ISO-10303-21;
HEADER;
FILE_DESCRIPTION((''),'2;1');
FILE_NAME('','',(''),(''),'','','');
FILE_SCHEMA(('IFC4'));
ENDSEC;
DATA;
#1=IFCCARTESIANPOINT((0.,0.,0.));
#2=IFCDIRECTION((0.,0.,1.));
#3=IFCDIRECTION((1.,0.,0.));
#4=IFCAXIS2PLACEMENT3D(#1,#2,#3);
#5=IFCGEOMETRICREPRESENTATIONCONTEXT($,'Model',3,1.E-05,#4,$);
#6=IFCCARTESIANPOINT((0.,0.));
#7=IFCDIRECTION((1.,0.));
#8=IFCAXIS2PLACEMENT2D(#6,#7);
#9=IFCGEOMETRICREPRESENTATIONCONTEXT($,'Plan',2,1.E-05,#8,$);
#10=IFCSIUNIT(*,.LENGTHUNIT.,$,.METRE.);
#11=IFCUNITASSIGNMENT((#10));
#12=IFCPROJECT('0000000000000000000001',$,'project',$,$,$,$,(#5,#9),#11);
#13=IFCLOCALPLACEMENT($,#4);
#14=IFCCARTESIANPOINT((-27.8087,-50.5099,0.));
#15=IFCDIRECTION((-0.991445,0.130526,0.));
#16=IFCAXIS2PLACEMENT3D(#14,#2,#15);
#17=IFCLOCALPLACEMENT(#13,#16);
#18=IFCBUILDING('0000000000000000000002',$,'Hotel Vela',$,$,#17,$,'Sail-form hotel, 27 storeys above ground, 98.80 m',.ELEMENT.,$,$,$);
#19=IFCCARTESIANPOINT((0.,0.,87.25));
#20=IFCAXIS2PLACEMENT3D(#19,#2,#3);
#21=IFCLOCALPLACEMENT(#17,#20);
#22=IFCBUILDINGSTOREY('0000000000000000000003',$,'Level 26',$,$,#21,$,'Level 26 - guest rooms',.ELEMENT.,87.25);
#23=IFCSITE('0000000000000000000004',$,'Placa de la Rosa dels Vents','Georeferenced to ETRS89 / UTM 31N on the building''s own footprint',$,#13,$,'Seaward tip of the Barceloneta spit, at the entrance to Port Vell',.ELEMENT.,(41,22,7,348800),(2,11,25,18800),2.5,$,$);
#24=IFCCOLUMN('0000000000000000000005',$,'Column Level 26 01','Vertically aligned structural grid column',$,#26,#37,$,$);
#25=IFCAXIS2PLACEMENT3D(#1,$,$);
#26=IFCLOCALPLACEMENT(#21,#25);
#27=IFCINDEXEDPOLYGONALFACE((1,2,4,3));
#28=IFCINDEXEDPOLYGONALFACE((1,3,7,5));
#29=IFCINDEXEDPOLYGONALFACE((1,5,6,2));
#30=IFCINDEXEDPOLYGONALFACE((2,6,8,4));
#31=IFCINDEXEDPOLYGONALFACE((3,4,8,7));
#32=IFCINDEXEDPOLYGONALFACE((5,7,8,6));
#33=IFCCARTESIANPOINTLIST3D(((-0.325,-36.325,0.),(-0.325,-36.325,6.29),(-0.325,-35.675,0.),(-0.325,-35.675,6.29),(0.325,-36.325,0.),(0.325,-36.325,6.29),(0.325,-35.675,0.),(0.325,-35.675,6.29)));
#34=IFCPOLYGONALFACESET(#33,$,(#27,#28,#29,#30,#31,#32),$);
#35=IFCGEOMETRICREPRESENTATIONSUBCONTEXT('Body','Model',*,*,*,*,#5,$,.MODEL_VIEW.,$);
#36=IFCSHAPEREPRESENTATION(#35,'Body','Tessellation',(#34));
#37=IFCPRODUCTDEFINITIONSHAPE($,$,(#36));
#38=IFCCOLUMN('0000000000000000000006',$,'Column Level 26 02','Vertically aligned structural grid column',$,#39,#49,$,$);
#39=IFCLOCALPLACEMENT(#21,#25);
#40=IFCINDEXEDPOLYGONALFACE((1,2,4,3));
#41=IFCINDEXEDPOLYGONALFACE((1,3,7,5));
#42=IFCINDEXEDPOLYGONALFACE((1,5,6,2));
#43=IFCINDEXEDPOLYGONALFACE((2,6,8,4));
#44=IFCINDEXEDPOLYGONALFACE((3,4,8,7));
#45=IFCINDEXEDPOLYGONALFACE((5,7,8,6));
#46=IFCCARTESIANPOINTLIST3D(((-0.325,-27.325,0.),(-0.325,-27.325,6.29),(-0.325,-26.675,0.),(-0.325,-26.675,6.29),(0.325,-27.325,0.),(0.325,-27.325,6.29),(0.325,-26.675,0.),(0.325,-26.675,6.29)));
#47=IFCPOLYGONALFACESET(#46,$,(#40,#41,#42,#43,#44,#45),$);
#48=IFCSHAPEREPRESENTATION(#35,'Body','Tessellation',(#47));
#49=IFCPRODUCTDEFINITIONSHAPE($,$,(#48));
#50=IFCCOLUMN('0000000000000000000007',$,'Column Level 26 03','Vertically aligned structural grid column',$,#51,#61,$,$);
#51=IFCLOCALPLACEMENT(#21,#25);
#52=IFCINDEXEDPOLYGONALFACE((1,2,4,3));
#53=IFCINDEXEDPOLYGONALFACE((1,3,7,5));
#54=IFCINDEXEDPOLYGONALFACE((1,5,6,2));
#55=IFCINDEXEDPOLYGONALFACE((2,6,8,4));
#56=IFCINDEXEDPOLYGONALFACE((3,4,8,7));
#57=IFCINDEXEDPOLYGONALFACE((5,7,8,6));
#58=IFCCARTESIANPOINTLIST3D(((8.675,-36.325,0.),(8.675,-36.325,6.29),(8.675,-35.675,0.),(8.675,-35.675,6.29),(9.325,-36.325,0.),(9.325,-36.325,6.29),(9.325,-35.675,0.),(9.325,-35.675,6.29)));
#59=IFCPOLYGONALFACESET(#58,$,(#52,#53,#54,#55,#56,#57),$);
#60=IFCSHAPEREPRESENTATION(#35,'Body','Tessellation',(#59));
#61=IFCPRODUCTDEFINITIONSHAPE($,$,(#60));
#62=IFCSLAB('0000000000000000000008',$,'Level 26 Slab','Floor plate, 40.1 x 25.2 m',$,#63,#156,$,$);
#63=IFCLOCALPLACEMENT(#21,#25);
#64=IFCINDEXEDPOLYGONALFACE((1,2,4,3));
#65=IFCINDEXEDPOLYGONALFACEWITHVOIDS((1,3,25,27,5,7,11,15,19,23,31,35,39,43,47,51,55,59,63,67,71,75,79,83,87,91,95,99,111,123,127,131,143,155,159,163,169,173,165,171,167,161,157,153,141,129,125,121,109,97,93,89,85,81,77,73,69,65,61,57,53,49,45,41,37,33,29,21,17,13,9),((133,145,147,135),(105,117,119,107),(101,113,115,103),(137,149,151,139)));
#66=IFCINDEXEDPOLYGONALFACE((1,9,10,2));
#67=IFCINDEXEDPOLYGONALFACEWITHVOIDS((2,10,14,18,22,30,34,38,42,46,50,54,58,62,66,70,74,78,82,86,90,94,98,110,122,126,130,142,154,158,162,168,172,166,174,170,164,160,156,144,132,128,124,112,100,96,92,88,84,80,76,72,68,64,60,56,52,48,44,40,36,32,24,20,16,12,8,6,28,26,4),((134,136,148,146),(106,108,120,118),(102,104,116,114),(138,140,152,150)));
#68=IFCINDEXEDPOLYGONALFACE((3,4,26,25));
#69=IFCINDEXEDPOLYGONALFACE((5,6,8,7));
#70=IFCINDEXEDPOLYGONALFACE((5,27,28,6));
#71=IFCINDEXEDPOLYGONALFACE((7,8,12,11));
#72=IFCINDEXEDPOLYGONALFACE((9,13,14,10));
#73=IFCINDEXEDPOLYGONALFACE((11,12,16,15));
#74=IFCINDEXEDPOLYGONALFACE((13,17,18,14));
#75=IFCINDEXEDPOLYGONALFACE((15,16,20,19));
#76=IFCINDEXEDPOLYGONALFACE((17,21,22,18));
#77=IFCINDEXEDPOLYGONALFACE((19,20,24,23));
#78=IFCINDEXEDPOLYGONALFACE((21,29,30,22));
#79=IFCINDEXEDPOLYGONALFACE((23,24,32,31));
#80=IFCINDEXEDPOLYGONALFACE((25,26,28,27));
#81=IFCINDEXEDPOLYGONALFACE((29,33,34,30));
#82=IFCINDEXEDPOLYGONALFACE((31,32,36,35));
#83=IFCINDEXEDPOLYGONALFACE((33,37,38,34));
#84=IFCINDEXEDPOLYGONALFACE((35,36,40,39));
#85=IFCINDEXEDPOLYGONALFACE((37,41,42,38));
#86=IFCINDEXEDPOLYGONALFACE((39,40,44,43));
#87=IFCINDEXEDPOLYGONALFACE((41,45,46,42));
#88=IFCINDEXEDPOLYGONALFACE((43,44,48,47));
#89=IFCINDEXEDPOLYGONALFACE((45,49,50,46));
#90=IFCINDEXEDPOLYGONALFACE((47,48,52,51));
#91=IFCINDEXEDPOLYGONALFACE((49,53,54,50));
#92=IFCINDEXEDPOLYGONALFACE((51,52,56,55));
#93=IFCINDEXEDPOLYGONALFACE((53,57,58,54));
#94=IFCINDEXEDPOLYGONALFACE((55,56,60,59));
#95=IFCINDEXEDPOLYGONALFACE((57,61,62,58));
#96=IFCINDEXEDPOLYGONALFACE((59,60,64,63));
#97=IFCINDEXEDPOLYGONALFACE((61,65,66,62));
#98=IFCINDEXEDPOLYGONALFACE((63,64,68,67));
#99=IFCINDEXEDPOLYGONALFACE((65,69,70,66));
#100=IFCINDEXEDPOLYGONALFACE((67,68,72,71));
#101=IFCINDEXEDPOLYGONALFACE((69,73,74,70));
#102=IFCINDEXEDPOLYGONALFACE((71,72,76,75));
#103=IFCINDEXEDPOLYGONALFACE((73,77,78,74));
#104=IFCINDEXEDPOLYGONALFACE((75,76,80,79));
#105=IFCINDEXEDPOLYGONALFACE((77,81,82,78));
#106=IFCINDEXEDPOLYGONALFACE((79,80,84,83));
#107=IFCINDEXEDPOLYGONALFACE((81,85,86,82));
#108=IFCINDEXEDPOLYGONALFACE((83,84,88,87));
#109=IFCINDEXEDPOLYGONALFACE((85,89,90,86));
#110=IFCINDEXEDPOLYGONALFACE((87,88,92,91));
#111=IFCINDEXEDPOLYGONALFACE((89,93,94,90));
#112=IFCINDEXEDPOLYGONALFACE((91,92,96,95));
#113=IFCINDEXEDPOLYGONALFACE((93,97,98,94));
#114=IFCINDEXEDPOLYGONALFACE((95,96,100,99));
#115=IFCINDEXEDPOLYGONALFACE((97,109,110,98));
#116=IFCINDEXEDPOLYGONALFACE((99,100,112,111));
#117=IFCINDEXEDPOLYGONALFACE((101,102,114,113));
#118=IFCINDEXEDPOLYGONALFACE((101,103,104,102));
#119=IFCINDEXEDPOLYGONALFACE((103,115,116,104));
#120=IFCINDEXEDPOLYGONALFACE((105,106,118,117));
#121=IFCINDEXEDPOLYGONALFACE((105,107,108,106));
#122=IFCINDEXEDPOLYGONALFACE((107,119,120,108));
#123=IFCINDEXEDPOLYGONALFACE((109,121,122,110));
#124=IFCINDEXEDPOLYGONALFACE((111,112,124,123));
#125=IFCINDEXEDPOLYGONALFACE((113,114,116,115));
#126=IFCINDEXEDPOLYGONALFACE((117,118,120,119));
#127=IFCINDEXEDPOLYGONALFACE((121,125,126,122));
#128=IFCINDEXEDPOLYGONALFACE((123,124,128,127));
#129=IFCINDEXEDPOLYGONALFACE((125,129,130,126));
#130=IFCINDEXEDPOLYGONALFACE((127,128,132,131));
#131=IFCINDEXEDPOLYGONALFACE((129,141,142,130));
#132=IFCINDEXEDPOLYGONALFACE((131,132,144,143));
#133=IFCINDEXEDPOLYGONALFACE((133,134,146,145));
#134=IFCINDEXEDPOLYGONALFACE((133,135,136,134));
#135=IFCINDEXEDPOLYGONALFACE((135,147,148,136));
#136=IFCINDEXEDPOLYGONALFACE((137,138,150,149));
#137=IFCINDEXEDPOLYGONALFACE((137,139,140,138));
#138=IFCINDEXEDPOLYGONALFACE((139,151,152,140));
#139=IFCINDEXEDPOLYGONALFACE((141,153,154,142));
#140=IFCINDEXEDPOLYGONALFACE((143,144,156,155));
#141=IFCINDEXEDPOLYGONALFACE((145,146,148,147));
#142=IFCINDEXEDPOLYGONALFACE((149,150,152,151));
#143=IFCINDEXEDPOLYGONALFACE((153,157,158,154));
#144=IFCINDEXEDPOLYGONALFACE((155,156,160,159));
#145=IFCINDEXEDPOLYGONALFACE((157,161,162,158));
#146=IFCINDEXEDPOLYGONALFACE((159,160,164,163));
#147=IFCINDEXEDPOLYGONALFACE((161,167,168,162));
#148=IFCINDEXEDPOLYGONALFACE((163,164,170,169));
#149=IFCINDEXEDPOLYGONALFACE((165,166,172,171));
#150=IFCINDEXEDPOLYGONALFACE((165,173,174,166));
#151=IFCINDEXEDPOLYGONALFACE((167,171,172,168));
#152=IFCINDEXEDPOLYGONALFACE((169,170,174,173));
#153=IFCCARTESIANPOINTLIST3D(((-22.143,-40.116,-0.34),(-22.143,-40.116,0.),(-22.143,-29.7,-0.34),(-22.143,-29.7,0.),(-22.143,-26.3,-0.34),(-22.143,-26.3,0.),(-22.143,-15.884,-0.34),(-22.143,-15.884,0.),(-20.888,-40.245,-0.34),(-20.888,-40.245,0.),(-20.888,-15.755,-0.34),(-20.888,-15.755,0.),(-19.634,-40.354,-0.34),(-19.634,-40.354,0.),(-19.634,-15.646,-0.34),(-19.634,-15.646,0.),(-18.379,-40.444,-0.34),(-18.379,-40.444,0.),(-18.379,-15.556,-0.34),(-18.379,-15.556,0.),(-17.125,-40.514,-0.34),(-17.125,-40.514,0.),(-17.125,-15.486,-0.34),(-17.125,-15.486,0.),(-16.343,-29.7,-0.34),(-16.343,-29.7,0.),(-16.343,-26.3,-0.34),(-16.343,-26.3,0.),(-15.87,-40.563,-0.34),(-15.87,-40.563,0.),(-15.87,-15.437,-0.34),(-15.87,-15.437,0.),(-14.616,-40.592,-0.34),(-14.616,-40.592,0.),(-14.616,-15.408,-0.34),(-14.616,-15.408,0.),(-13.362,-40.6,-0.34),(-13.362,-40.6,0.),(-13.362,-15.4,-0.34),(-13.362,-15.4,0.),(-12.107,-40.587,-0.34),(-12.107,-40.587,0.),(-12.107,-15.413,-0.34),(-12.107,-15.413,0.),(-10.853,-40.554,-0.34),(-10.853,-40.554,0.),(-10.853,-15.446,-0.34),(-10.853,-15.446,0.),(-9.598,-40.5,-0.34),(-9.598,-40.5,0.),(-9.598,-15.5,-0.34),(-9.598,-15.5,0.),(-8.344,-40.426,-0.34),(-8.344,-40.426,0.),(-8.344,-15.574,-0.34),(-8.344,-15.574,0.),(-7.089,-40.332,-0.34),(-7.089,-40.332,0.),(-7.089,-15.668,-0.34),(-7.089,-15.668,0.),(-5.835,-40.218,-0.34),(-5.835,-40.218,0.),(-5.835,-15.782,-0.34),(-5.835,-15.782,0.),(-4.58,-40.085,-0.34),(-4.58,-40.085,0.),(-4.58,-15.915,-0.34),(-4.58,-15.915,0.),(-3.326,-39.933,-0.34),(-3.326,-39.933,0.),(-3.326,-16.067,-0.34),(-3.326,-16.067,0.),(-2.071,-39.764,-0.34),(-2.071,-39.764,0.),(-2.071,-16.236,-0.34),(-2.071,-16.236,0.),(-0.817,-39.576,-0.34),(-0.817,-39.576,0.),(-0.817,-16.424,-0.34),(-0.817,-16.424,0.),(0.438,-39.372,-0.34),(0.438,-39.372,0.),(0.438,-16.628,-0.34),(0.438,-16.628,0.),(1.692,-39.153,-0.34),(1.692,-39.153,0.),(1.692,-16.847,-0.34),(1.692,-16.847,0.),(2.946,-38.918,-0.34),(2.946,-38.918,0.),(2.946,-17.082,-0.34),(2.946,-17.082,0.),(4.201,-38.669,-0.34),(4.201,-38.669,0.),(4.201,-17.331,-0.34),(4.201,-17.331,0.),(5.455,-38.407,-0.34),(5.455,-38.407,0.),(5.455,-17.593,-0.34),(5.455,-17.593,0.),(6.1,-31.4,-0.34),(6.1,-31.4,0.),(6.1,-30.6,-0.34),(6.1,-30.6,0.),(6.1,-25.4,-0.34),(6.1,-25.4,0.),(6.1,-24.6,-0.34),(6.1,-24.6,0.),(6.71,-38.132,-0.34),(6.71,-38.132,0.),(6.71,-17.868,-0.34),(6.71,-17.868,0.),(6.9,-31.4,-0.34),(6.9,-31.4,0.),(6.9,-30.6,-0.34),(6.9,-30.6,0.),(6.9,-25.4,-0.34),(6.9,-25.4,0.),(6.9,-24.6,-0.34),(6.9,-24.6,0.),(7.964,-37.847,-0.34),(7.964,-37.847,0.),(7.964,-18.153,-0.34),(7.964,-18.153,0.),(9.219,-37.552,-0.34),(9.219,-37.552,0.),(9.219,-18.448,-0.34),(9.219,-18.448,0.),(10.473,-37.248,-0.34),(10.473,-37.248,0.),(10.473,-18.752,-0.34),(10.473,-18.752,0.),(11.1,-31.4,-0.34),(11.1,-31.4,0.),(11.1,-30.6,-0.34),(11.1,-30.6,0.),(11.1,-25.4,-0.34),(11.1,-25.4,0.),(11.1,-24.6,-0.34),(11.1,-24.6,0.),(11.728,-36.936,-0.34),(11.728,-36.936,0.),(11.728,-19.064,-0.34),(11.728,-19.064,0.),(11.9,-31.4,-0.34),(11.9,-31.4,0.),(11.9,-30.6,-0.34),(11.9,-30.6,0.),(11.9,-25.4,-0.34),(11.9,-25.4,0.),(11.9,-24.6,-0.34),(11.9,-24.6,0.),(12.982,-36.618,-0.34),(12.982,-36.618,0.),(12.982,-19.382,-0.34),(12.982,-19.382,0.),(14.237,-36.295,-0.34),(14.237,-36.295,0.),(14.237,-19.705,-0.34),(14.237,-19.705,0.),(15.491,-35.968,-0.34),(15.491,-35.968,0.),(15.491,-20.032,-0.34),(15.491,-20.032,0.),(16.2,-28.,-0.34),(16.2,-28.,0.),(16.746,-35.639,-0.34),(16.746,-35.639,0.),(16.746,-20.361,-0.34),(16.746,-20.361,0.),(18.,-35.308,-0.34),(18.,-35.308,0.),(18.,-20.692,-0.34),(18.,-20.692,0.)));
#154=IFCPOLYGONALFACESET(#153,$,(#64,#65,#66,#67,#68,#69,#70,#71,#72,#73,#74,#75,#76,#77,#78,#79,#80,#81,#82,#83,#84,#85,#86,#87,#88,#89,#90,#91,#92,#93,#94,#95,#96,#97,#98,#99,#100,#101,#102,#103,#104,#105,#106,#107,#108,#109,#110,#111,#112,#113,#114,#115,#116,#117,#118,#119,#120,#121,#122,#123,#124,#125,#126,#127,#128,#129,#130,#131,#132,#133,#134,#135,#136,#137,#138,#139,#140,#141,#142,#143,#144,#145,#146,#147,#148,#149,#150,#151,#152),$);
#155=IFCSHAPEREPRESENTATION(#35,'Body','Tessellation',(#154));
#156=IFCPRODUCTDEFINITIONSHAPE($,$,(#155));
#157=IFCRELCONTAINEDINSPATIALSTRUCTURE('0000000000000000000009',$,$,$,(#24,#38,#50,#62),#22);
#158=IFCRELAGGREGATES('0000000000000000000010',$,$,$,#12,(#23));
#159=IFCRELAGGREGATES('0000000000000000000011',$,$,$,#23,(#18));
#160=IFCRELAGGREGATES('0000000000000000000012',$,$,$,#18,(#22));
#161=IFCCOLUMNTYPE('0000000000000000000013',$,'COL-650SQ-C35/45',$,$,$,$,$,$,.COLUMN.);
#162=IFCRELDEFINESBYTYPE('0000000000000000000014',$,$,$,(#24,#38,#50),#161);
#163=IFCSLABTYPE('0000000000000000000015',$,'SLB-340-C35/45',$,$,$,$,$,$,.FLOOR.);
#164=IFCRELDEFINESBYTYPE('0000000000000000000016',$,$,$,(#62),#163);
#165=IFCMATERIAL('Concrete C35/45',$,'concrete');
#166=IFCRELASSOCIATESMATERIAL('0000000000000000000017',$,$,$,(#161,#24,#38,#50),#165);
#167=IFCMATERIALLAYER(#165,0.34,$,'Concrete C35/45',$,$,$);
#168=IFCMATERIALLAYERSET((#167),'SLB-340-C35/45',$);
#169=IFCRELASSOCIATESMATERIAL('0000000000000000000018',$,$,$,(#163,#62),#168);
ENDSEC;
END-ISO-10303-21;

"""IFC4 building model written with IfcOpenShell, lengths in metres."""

from ifc_helpers import new_model, si_unit, frame, origin_with_axes, origin_2d_with_axis, place, context, subcontext, project, spatial, line, indexed_curve, rectangle, outline, extrude, material, layer, layer_set, layer_usage, material_profile, profile_set, profile_usage, type_object, element, save


model = new_model("IFC4")

# Units and contexts
model_context = context("Model", 3, precision=1e-05, world=origin_with_axes())
plan_context = context("Plan", 2, precision=1e-05, world=origin_2d_with_axis())
body_context = subcontext(model_context, "Body", "Model", "MODEL_VIEW")
ifc_project = project(units=[si_unit("LENGTHUNIT", "METRE")], contexts=[model_context, plan_context])

# Site, building, storey
site_placement = place(None, origin_with_axes())
site = spatial("IfcSite", under=ifc_project, at=site_placement, Name="Placa de la Rosa dels Vents", Description="Georeferenced to ETRS89 / UTM 31N on the building's own footprint", LongName="Seaward tip of the Barceloneta spit, at the entrance to Port Vell", CompositionType="ELEMENT", RefLatitude=(41, 22, 7, 348800), RefLongitude=(2, 11, 25, 18800), RefElevation=2.5)
building_placement = place(site_placement, frame((-27.8087, -50.5099, 0.0), z_axis=(0.0, 0.0, 1.0), x_axis=(-0.991445, 0.130526, 0.0)))
building = spatial("IfcBuilding", under=site, at=building_placement, Name="Hotel Vela", LongName="Sail-form hotel, 27 storeys above ground, 98.80 m", CompositionType="ELEMENT")
storey_placement = place(building_placement, frame((0.0, 0.0, 87.25), z_axis=(0.0, 0.0, 1.0), x_axis=(1.0, 0.0, 0.0)))
storey = spatial("IfcBuildingStorey", under=building, at=storey_placement, Name="Level 26", LongName="Level 26 - guest rooms", CompositionType="ELEMENT", Elevation=87.25)

# Columns
ifc_material = material(Name="Concrete C35/45", Category="concrete")
ifc_material_profile = material_profile(ifc_material, rectangle(XDim=0.65, YDim=0.65))
ifc_profile_set = profile_set([ifc_material_profile], Name="COL-650SQ-C35/45")
ifc_profile_usage_1 = profile_usage(ifc_profile_set)
column_type = type_object("IfcColumnType", Name="COL-650SQ-C35/45", PredefinedType="COLUMN", material=ifc_profile_set)
column_1_placement = place(storey_placement, frame((-0.325, -36.325, 0.0), z_axis=(0.0, 0.0, 1.0), x_axis=(1.0, 0.0, 0.0)))
element("IfcColumn", 1, at=column_1_placement, inside=storey, type_object=column_type, material=ifc_profile_usage_1, Name="Column Level 26 01", Description="Vertically aligned structural grid column", context=body_context, shape_type="SweptSolid", body=[
    extrude(outline(indexed_curve([(0.0, 0.0), (0.65, 0.0), (0.65, 0.65), (0.0, 0.65)], segments=[line(1, 2, 3, 4, 1)])), origin_with_axes(), (0.0, 0.0, 1.0), 6.29),
])
ifc_profile_usage_2 = profile_usage(ifc_profile_set)
column_2_placement = place(storey_placement, frame((-0.325, -27.325, 0.0), z_axis=(0.0, 0.0, 1.0), x_axis=(1.0, 0.0, 0.0)))
element("IfcColumn", 2, at=column_2_placement, inside=storey, type_object=column_type, material=ifc_profile_usage_2, Name="Column Level 26 02", Description="Vertically aligned structural grid column", context=body_context, shape_type="SweptSolid", body=[
    extrude(outline(indexed_curve([(0.0, 0.0), (0.65, 0.0), (0.65, 0.65), (0.0, 0.65)], segments=[line(1, 2, 3, 4, 1)])), origin_with_axes(), (0.0, 0.0, 1.0), 6.29),
])
ifc_profile_usage_3 = profile_usage(ifc_profile_set)
column_3_placement = place(storey_placement, frame((8.675, -36.325, 0.0), z_axis=(0.0, 0.0, 1.0), x_axis=(1.0, 0.0, 0.0)))
element("IfcColumn", 3, at=column_3_placement, inside=storey, type_object=column_type, material=ifc_profile_usage_3, Name="Column Level 26 03", Description="Vertically aligned structural grid column", context=body_context, shape_type="SweptSolid", body=[
    extrude(outline(indexed_curve([(0.0, 0.0), (0.65, 0.0), (0.65, 0.65), (0.0, 0.65)], segments=[line(1, 2, 3, 4, 1)])), origin_with_axes(), (0.0, 0.0, 1.0), 6.29),
])

# Slab, openings
ifc_layer_1 = layer(ifc_material, 0.34, Name="Concrete C35/45")
ifc_layer_set_1 = layer_set([ifc_layer_1], Name="SLB-340-C35/45")
ifc_layer_usage_1 = layer_usage(ifc_layer_set_1, "AXIS3", "POSITIVE", 0.0)
slab_type = type_object("IfcSlabType", Name="SLB-340-C35/45", PredefinedType="FLOOR", material=ifc_layer_set_1)
slab_placement = place(storey_placement, frame((0.0, 0.0, -0.34), z_axis=(0.0, 0.0, 1.0), x_axis=(1.0, 0.0, 0.0)))
slab = element("IfcSlab", 4, at=slab_placement, inside=storey, type_object=slab_type, material=ifc_layer_usage_1, Name="Level 26 Slab", Description="Floor plate, 40.1 x 25.2 m", context=body_context, shape_type="SweptSolid", body=[
    extrude(outline(indexed_curve([(-22.143, -40.116), (-20.888, -40.245), (-19.634, -40.354), (-18.379, -40.444), (-17.125, -40.514), (-15.87, -40.563), (-14.616, -40.592), (-13.362, -40.6), (-12.107, -40.587), (-10.853, -40.554), (-9.598, -40.5), (-8.344, -40.426), (-7.089, -40.332), (-5.835, -40.218), (-4.58, -40.085), (-3.326, -39.933), (-2.071, -39.764), (-0.817, -39.576), (0.438, -39.372), (1.692, -39.153), (2.946, -38.918), (4.201, -38.669), (5.455, -38.407), (6.71, -38.132), (7.964, -37.847), (9.219, -37.552), (10.473, -37.248), (11.728, -36.936), (12.982, -36.618), (14.237, -36.295), (15.491, -35.968), (16.746, -35.639), (18.0, -35.308), (16.2, -28.0), (18.0, -20.692), (16.746, -20.361), (15.491, -20.032), (14.237, -19.705), (12.982, -19.382), (11.728, -19.064), (10.473, -18.752), (9.219, -18.448), (7.964, -18.153), (6.71, -17.868), (5.455, -17.593), (4.201, -17.331), (2.946, -17.082), (1.692, -16.847), (0.438, -16.628), (-0.817, -16.424), (-2.071, -16.236), (-3.326, -16.067), (-4.58, -15.915), (-5.835, -15.782), (-7.089, -15.668), (-8.344, -15.574), (-9.598, -15.5), (-10.853, -15.446), (-12.107, -15.413), (-13.362, -15.4), (-14.616, -15.408), (-15.87, -15.437), (-17.125, -15.486), (-18.379, -15.556), (-19.634, -15.646), (-20.888, -15.755), (-22.143, -15.884), (-22.143, -26.3), (-16.343, -26.3), (-16.343, -29.7), (-22.143, -29.7)], segments=[line(1, 2, 3, 4, 5, 6, 7, 8, 9, 10, 11, 12, 13, 14, 15, 16, 17, 18, 19, 20, 21, 22, 23, 24, 25, 26, 27, 28, 29, 30, 31, 32, 33, 34, 35, 36, 37, 38, 39, 40, 41, 42, 43, 44, 45, 46, 47, 48, 49, 50, 51, 52, 53, 54, 55, 56, 57, 58, 59, 60, 61, 62, 63, 64, 65, 66, 67, 68, 69, 70, 71, 1)])), origin_with_axes(), (0.0, 0.0, 1.0), 0.34),
])
opening_1_placement = place(slab_placement, frame((6.1, -31.4, -0.05), z_axis=(0.0, 0.0, 1.0), x_axis=(1.0, 0.0, 0.0)))
element("IfcOpeningElement", 5, at=opening_1_placement, cuts=slab, PredefinedType="OPENING", context=body_context, shape_type="SweptSolid", body=[
    extrude(outline(indexed_curve([(0.0, 0.0), (0.8, 0.0), (0.8, 0.8), (0.0, 0.8)], segments=[line(1, 2, 3, 4, 1)])), origin_with_axes(), (0.0, 0.0, 1.0), 0.44),
])
opening_2_placement = place(slab_placement, frame((6.1, -25.4, -0.05), z_axis=(0.0, 0.0, 1.0), x_axis=(1.0, 0.0, 0.0)))
element("IfcOpeningElement", 6, at=opening_2_placement, cuts=slab, PredefinedType="OPENING", context=body_context, shape_type="SweptSolid", body=[
    extrude(outline(indexed_curve([(0.0, 0.0), (0.8, 0.0), (0.8, 0.8), (0.0, 0.8)], segments=[line(1, 2, 3, 4, 1)])), origin_with_axes(), (0.0, 0.0, 1.0), 0.44),
])
opening_3_placement = place(slab_placement, frame((11.1, -31.4, -0.05), z_axis=(0.0, 0.0, 1.0), x_axis=(1.0, 0.0, 0.0)))
element("IfcOpeningElement", 7, at=opening_3_placement, cuts=slab, PredefinedType="OPENING", context=body_context, shape_type="SweptSolid", body=[
    extrude(outline(indexed_curve([(0.0, 0.0), (0.8, 0.0), (0.8, 0.8), (0.0, 0.8)], segments=[line(1, 2, 3, 4, 1)])), origin_with_axes(), (0.0, 0.0, 1.0), 0.44),
])
opening_4_placement = place(slab_placement, frame((11.1, -25.4, -0.05), z_axis=(0.0, 0.0, 1.0), x_axis=(1.0, 0.0, 0.0)))
element("IfcOpeningElement", 8, at=opening_4_placement, cuts=slab, PredefinedType="OPENING", context=body_context, shape_type="SweptSolid", body=[
    extrude(outline(indexed_curve([(0.0, 0.0), (0.8, 0.0), (0.8, 0.8), (0.0, 0.8)], segments=[line(1, 2, 3, 4, 1)])), origin_with_axes(), (0.0, 0.0, 1.0), 0.44),
])

save(model, "model.ifc")
